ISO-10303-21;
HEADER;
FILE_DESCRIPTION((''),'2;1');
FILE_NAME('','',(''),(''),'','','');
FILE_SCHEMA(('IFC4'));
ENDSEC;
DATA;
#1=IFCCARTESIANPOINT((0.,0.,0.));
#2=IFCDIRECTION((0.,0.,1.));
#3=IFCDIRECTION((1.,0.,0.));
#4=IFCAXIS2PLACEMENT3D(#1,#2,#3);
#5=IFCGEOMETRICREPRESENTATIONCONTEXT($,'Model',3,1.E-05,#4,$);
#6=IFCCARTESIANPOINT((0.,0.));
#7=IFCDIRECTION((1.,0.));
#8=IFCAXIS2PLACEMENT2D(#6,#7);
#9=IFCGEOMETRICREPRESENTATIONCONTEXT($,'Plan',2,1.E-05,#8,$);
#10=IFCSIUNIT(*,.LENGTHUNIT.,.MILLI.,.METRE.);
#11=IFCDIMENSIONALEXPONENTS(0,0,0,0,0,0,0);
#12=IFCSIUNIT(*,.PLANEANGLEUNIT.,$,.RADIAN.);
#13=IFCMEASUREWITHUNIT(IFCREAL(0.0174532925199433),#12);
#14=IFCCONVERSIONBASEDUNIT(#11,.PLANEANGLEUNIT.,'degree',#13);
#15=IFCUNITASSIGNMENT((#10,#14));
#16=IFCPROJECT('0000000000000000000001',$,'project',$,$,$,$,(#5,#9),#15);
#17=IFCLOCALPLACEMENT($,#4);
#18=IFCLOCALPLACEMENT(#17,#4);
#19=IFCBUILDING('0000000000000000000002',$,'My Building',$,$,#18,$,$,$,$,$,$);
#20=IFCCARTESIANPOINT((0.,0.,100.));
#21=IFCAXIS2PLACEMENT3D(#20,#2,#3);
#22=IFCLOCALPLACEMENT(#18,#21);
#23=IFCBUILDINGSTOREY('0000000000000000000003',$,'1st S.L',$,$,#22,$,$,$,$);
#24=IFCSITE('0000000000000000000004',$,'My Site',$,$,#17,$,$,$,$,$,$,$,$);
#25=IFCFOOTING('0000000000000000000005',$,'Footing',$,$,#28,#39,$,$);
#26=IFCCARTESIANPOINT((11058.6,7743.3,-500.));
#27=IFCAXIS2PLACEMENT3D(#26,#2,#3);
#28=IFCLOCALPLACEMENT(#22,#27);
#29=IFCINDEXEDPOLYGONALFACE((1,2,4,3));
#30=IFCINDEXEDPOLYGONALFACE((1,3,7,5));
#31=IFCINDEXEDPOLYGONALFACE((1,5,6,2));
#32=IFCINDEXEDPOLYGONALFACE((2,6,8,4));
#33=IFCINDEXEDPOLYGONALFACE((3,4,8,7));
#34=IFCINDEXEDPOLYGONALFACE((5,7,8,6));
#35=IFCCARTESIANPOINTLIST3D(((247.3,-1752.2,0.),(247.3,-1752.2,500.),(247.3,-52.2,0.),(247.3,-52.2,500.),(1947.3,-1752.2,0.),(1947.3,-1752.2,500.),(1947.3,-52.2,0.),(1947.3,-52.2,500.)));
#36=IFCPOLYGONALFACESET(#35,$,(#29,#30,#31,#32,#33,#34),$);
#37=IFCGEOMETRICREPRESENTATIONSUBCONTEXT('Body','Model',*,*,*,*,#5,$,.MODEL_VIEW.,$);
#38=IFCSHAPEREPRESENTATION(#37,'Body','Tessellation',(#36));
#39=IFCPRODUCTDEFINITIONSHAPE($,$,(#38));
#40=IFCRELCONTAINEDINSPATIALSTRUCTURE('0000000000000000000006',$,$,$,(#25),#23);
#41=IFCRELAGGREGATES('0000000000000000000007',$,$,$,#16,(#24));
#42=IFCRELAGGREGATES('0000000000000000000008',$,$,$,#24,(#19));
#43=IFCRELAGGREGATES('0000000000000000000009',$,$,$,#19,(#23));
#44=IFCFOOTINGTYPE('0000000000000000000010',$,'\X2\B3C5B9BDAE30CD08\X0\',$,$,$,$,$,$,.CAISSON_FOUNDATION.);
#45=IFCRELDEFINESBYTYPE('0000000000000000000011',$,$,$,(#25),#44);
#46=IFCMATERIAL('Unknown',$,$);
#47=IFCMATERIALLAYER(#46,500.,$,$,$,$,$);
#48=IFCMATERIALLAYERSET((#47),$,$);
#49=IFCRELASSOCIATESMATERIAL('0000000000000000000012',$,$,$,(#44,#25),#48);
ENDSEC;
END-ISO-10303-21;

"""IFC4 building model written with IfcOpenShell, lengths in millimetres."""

from ifc_helpers import new_model, entity, si_unit, converted_unit, frame, origin_with_axes, origin_2d_with_axis, place, context, subcontext, project, spatial, indexed_curve, outline, extrude, material, layer, layer_set, layer_usage, type_object, element, save


model = new_model("IFC4")

# Units and contexts
model_context = context("Model", 3, precision=1e-05, world=origin_with_axes())
plan_context = context("Plan", 2, precision=1e-05, world=origin_2d_with_axis())
body_context_1 = subcontext(model_context, "Body", "Model", "MODEL_VIEW")
ifc_project = project(units=[si_unit("LENGTHUNIT", "METRE", prefix="MILLI"), converted_unit("PLANEANGLEUNIT", "degree", entity("IfcReal", 0.0174532925199433), si_unit("PLANEANGLEUNIT", "RADIAN"), dimensions=[0, 0, 0, 0, 0, 0, 0])], contexts=[model_context, plan_context])

# Site, building, storey
site_placement = place(None, origin_with_axes())
site = spatial("IfcSite", under=ifc_project, at=site_placement, Name="My Site")
building_placement = place(site_placement, origin_with_axes())
building = spatial("IfcBuilding", under=site, at=building_placement, Name="My Building")
storey_placement = place(building_placement, frame((0.0, 0.0, 100.0), z_axis=(0.0, 0.0, 1.0), x_axis=(1.0, 0.0, 0.0)))
storey = spatial("IfcBuildingStorey", under=building, at=storey_placement, Name="1st S.L")

# Footing
ifc_material_1 = material(Name="Unknown")
ifc_layer_1 = layer(ifc_material_1, 500.0)
ifc_layer_set_1 = layer_set([ifc_layer_1])
ifc_layer_usage_1 = layer_usage(ifc_layer_set_1, "AXIS3", "POSITIVE", 0.0)
footing_type = type_object("IfcFootingType", Name="독립기초", PredefinedType="CAISSON_FOUNDATION", material=ifc_layer_set_1)
footing_placement = place(storey_placement, frame((11058.6, 7743.3, -500.0), z_axis=(0.0, 0.0, 1.0), x_axis=(1.0, 0.0, 0.0)))
element("IfcFooting", 1, at=footing_placement, inside=storey, type_object=footing_type, material=ifc_layer_usage_1, Name="Footing", context=body_context_1, shape_type="SolidModel", body=[
    extrude(outline(indexed_curve([(1947.3, -52.2), (1947.3, -1752.2), (247.3, -1752.2), (247.3, -52.2), (1947.3, -52.2)])), origin_with_axes(), (0.0, 0.0, 1.0), 500.0),
])

save(model, "model.ifc")
